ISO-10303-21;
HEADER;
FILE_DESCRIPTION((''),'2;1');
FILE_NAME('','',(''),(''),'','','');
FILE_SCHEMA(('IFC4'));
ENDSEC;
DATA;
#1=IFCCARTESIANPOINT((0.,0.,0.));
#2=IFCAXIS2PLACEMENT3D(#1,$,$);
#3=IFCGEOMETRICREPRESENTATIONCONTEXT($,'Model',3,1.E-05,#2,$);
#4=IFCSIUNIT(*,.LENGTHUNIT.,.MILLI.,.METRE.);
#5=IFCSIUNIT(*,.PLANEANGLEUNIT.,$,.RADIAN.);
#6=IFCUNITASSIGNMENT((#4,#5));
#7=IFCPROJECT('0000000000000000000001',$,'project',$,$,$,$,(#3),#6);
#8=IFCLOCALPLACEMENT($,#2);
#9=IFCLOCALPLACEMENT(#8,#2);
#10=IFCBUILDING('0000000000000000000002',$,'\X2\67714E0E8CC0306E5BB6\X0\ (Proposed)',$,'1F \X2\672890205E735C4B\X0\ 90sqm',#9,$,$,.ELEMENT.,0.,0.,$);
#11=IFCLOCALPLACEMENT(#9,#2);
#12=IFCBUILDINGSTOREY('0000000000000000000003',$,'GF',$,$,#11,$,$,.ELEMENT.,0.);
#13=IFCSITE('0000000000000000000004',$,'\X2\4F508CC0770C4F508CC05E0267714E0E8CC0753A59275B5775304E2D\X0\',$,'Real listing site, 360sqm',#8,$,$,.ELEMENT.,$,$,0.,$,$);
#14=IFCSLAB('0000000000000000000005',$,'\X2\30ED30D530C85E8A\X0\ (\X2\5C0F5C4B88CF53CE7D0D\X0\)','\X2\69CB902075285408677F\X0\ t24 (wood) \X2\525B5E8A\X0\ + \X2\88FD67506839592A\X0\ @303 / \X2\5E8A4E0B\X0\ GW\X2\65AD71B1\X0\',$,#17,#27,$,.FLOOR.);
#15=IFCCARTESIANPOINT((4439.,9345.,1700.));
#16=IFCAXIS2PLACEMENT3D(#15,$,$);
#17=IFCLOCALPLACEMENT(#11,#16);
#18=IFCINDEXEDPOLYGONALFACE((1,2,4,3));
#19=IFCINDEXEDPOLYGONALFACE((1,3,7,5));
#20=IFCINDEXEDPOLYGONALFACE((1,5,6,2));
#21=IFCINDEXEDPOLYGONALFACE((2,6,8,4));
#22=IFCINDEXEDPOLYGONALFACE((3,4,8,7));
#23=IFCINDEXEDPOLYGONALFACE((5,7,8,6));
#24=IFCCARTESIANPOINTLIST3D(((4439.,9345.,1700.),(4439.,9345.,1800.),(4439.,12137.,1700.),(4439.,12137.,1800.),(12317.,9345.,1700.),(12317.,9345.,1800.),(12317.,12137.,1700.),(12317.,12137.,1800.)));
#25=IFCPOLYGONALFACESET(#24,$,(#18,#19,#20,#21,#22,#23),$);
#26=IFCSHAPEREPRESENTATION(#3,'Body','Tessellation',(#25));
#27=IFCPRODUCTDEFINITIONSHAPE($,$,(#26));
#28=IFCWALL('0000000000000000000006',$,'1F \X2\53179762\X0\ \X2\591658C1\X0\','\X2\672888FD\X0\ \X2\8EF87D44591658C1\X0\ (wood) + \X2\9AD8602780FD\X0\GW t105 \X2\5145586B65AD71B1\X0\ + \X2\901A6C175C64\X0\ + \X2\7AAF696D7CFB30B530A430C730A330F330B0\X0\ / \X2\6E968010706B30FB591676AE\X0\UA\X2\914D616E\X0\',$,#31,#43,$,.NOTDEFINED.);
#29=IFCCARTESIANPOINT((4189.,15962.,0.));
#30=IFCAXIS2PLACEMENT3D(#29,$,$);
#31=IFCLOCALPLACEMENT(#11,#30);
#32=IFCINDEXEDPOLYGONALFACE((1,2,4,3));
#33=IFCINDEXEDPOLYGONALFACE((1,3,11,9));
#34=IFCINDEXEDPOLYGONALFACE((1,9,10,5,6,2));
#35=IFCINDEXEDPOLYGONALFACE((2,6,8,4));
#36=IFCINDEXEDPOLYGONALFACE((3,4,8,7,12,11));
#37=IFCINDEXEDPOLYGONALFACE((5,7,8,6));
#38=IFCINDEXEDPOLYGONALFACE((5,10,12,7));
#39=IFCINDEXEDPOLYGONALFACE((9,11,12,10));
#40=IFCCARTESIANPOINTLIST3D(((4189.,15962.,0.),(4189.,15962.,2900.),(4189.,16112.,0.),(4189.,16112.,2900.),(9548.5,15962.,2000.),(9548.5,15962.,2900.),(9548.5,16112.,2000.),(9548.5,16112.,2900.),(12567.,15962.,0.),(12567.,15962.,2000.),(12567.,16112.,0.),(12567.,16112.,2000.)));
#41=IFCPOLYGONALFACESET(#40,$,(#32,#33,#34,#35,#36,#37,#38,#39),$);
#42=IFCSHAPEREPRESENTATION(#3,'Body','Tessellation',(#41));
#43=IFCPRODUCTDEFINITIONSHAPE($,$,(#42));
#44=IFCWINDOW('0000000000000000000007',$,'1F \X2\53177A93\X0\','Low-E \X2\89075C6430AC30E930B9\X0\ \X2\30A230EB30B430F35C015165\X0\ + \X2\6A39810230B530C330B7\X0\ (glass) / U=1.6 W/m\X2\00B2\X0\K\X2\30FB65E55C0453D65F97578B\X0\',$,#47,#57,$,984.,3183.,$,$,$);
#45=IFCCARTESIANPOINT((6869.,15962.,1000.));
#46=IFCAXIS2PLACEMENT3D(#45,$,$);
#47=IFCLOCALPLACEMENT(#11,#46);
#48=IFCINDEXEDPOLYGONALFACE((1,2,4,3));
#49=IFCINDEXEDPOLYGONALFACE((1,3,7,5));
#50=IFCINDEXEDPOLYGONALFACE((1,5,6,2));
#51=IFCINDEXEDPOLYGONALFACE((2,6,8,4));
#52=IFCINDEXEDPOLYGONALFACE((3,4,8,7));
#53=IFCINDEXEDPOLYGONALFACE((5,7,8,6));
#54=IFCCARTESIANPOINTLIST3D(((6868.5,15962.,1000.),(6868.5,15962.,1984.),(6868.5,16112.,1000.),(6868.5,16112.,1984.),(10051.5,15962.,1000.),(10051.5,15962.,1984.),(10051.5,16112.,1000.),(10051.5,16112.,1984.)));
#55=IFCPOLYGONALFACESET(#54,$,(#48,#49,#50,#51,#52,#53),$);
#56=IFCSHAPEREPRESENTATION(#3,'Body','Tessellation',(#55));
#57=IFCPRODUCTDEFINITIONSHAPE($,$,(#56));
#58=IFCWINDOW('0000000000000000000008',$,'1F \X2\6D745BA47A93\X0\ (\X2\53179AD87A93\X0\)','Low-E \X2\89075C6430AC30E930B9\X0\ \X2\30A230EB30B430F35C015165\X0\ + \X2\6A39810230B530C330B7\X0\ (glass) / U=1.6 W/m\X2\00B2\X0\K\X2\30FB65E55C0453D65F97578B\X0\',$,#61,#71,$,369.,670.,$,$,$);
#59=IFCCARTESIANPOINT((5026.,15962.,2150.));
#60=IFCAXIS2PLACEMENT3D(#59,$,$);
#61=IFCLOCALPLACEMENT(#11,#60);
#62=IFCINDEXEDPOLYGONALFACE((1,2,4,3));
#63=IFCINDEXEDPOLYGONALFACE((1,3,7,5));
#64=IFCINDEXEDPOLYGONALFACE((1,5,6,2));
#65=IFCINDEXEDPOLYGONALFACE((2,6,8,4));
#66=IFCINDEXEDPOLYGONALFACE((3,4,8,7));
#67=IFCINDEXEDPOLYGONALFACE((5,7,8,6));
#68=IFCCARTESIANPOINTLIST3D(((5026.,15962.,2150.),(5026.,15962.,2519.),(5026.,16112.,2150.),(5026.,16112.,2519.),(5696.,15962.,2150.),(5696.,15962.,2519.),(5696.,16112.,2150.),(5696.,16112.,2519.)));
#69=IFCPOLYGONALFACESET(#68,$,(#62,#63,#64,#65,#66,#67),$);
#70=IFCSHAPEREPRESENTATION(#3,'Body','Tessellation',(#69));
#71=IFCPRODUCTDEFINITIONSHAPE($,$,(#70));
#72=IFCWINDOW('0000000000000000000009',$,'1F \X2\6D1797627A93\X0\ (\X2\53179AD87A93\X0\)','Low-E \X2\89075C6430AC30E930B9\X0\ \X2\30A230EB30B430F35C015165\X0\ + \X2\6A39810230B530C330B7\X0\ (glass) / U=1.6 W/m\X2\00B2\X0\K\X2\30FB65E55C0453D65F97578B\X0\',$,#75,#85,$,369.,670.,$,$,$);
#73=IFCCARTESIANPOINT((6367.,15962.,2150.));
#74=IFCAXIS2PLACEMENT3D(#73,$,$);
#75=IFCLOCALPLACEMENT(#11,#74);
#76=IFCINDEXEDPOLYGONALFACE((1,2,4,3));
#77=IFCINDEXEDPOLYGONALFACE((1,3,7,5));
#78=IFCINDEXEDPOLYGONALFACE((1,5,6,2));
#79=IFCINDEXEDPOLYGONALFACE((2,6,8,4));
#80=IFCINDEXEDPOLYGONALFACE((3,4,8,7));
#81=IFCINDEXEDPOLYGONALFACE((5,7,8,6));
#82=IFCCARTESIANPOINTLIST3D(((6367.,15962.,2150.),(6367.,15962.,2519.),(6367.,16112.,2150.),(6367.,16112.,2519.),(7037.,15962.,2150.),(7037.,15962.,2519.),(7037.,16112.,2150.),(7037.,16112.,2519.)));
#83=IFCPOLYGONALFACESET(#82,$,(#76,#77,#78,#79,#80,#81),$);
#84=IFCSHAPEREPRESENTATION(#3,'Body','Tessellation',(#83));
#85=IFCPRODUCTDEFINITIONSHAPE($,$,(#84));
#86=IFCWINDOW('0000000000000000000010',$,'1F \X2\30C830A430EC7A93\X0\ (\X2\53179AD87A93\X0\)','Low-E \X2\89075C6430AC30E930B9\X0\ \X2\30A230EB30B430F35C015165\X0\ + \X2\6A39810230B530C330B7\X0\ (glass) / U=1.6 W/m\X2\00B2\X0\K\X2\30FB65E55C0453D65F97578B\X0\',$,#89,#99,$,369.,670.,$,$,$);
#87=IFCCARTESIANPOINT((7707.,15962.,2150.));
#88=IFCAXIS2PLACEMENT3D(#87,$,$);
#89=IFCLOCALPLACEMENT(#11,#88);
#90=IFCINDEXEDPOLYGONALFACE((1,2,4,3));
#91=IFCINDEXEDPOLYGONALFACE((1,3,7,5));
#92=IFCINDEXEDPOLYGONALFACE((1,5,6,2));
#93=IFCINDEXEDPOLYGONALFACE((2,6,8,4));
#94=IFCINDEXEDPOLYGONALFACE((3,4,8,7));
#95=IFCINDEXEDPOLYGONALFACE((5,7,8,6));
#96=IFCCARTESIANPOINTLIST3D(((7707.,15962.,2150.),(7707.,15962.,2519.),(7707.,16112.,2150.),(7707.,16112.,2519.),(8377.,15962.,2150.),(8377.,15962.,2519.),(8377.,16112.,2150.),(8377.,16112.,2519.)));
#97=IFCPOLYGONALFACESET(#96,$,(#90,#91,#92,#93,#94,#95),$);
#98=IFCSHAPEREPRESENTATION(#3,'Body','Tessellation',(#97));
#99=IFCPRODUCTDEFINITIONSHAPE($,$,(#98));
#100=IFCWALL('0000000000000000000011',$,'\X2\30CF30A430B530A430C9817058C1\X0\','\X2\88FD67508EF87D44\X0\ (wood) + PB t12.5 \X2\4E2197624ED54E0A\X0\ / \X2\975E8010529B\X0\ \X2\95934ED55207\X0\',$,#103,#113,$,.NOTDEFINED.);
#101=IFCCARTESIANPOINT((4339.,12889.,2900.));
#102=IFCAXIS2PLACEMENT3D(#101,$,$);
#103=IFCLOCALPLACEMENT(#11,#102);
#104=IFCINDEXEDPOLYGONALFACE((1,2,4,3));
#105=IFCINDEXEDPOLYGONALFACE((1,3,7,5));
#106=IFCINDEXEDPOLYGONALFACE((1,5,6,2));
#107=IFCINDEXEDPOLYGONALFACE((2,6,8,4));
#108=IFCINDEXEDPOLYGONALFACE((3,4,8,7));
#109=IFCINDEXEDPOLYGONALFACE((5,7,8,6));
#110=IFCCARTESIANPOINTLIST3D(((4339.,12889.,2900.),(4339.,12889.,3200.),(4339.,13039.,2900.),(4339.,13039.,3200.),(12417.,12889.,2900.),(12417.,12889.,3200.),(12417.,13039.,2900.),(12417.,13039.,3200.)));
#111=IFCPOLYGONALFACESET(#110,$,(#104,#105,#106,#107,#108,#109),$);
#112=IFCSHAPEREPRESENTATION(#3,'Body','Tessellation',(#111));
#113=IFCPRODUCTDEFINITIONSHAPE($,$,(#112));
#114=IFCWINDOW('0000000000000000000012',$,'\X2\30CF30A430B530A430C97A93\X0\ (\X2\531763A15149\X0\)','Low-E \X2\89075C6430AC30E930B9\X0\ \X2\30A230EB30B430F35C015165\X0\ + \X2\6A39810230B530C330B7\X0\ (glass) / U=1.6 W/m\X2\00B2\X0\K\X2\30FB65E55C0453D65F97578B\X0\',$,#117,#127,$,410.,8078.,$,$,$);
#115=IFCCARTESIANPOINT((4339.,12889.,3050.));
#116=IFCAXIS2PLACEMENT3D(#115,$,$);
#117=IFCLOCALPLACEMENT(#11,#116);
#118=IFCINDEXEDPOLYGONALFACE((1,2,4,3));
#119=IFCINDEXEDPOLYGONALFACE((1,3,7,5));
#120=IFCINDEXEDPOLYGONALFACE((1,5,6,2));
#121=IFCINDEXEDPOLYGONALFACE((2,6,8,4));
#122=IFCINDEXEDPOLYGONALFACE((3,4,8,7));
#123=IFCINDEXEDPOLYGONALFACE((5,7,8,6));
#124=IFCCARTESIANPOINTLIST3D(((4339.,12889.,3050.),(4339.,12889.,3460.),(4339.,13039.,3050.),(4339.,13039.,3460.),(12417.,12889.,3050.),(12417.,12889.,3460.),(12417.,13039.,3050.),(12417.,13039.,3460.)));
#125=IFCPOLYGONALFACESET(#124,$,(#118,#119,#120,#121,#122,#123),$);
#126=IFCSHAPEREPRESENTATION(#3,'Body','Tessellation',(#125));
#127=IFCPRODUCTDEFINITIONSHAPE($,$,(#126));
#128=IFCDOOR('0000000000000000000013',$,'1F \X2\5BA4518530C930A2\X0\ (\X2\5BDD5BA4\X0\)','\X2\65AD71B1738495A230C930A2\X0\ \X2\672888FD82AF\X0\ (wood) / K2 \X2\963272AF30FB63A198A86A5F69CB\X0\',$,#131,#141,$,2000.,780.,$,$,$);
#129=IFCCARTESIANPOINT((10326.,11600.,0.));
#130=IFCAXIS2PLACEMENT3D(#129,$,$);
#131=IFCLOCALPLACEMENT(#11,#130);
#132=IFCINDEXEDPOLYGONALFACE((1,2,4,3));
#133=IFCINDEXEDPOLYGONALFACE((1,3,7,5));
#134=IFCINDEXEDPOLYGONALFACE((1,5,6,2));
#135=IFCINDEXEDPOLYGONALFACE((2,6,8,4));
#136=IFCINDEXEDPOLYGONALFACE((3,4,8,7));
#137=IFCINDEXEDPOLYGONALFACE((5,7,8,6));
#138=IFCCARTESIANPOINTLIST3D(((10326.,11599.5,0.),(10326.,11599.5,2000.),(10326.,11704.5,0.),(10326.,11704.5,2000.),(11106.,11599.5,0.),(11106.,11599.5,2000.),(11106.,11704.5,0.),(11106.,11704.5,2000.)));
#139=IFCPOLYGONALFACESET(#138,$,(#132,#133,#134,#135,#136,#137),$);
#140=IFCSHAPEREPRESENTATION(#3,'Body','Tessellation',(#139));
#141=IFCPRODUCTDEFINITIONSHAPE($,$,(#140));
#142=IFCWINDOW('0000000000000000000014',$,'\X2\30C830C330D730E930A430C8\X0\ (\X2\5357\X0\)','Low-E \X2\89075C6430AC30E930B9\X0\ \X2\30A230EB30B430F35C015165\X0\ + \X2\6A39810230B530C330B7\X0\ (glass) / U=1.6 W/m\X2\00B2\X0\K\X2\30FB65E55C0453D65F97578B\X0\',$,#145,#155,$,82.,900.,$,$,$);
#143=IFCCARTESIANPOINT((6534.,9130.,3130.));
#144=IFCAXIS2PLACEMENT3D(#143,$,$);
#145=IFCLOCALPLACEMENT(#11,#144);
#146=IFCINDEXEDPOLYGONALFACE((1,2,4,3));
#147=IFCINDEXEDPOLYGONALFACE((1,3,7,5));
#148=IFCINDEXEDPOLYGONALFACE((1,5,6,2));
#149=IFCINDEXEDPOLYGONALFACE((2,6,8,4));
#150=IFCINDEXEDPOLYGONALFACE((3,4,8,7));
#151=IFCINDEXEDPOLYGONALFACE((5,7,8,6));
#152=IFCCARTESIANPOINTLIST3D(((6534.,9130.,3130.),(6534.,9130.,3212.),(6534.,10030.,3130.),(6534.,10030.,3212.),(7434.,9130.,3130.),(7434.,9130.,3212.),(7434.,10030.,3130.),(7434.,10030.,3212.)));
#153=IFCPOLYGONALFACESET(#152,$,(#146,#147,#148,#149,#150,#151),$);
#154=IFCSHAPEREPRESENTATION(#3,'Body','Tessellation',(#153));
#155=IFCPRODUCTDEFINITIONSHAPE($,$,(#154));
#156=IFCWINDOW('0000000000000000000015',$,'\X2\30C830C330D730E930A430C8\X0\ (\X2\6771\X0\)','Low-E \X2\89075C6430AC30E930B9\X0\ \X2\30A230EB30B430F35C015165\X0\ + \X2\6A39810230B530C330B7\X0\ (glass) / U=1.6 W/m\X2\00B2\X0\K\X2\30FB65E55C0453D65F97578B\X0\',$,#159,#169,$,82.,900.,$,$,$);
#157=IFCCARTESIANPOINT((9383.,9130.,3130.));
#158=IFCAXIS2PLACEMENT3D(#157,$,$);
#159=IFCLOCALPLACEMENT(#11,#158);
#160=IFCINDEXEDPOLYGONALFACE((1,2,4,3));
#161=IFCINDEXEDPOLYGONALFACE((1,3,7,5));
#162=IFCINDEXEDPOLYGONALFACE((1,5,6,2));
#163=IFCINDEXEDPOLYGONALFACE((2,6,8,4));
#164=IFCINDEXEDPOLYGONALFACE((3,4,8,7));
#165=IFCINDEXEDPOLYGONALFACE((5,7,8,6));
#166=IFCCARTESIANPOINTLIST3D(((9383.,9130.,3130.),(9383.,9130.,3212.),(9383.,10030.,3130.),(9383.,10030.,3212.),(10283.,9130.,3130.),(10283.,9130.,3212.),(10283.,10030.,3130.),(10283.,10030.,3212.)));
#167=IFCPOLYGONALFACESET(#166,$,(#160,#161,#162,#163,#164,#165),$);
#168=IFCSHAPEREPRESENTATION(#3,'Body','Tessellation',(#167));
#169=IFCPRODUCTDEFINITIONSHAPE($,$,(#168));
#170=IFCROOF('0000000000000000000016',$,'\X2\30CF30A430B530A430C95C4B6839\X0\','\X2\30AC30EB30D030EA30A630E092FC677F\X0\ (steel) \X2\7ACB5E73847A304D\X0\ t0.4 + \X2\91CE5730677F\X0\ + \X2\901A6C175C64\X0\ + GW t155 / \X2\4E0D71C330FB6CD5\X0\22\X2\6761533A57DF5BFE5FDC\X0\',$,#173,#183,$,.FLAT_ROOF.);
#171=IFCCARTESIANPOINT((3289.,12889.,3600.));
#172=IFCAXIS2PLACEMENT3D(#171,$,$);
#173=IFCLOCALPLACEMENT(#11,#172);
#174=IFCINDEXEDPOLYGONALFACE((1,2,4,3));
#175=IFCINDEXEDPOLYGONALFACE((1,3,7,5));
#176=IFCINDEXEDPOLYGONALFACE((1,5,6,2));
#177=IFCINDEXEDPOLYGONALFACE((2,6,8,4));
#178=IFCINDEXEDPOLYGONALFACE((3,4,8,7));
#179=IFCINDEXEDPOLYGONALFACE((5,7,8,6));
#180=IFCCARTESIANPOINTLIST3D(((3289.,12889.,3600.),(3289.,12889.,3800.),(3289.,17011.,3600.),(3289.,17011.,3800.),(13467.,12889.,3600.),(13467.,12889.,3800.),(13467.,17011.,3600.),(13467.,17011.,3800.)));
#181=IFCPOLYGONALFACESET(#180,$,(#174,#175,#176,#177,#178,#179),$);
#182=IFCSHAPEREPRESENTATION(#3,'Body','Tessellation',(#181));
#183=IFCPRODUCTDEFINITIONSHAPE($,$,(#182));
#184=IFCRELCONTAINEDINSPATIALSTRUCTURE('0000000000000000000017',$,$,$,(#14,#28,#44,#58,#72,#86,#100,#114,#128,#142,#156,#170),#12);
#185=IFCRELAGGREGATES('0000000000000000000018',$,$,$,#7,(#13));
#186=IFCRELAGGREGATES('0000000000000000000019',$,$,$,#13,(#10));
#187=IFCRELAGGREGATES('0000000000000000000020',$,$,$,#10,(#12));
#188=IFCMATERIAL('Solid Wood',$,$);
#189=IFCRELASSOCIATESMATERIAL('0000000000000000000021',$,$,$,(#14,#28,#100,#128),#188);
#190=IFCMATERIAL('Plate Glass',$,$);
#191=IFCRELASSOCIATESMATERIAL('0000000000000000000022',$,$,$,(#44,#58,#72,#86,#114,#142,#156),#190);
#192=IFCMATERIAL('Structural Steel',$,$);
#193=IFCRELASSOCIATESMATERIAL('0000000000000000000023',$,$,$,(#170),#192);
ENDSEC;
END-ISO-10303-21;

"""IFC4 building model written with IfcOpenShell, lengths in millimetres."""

from ifc_helpers import new_model, si_unit, frame, frame_2d, origin, place, context, project, spatial, rectangle, extrude, material, element, fill, save


model = new_model("IFC4")

# Units and contexts
model_context = context("Model", 3, precision=1e-05, world=origin())
ifc_project = project(units=[si_unit("LENGTHUNIT", "METRE", prefix="MILLI"), si_unit("PLANEANGLEUNIT", "RADIAN")], contexts=[model_context])

# Site, building, storey
site_placement = place(None, origin())
site = spatial("IfcSite", under=ifc_project, at=site_placement, Name="佐賀県佐賀市東与賀町大字田中", ObjectType="Real listing site, 360sqm", CompositionType="ELEMENT", RefElevation=0.0)
building_placement = place(site_placement, origin())
building = spatial("IfcBuilding", under=site, at=building_placement, Name="東与賀の家 (Proposed)", ObjectType="1F 木造平屋 90sqm", CompositionType="ELEMENT", ElevationOfRefHeight=0.0, ElevationOfTerrain=0.0)
storey_placement = place(building_placement, origin())
storey = spatial("IfcBuildingStorey", under=building, at=storey_placement, Name="GF", CompositionType="ELEMENT", Elevation=0.0)

# Slab
ifc_material_1 = material(Name="Solid Wood")
slab_placement = place(storey_placement, frame((4439.0, 9345.0, 1700.0)))
element("IfcSlab", 1, at=slab_placement, inside=storey, material=ifc_material_1, Name="ロフト床 (小屋裏収納)", Description="構造用合板 t24 (wood) 剛床 + 製材根太 @303 / 床下 GW断熱", PredefinedType="FLOOR", context=model_context, shape_type="SweptSolid", body=[
    extrude(rectangle(XDim=7878.0, YDim=2792.0, at=frame_2d((3939.0, 1396.0))), frame((4439.0, 9345.0, 1700.0)), (0.0, 0.0, 1.0), 100.0),
])

# Wall, openings, windows
wall_1_placement = place(storey_placement, frame((4189.0, 15962.0, 0.0)))
wall_1 = element("IfcWall", 2, at=wall_1_placement, inside=storey, material=ifc_material_1, Name="1F 北面 外壁", Description="木製 軸組外壁 (wood) + 高性能GW t105 充填断熱 + 通気層 + 窯業系サイディング / 準耐火・外皮UA配慮", PredefinedType="NOTDEFINED", context=model_context, shape_type="SweptSolid", body=[
    extrude(rectangle(XDim=8378.0, YDim=150.0, at=frame_2d((4189.0, 75.0))), frame((4189.0, 15962.0, 0.0)), (0.0, 0.0, 1.0), 2900.0),
])
opening_1_placement = place(storey_placement, frame((6869.0, 15962.0, 1000.0)))
opening_1 = element("IfcOpeningElement", 3, at=opening_1_placement, cuts=wall_1, PredefinedType="NOTDEFINED", context=model_context, shape_type="SweptSolid", body=[
    extrude(rectangle(XDim=3183.0, YDim=150.0, at=frame_2d((1591.0, 75.0))), frame((6869.0, 15962.0, 1000.0)), (0.0, 0.0, 1.0), 984.0),
])
opening_2_placement = place(storey_placement, frame((5026.0, 15962.0, 2150.0)))
opening_2 = element("IfcOpeningElement", 4, at=opening_2_placement, cuts=wall_1, PredefinedType="NOTDEFINED", context=model_context, shape_type="SweptSolid", body=[
    extrude(rectangle(XDim=670.0, YDim=150.0, at=frame_2d((335.0, 75.0))), frame((5026.0, 15962.0, 2150.0)), (0.0, 0.0, 1.0), 369.0),
])
opening_3_placement = place(storey_placement, frame((6367.0, 15962.0, 2150.0)))
opening_3 = element("IfcOpeningElement", 5, at=opening_3_placement, cuts=wall_1, PredefinedType="NOTDEFINED", context=model_context, shape_type="SweptSolid", body=[
    extrude(rectangle(XDim=670.0, YDim=150.0, at=frame_2d((335.0, 75.0))), frame((6367.0, 15962.0, 2150.0)), (0.0, 0.0, 1.0), 369.0),
])
opening_4_placement = place(storey_placement, frame((7707.0, 15962.0, 2150.0)))
opening_4 = element("IfcOpeningElement", 6, at=opening_4_placement, cuts=wall_1, PredefinedType="NOTDEFINED", context=model_context, shape_type="SweptSolid", body=[
    extrude(rectangle(XDim=670.0, YDim=150.0, at=frame_2d((335.0, 75.0))), frame((7707.0, 15962.0, 2150.0)), (0.0, 0.0, 1.0), 369.0),
])
ifc_material_2 = material(Name="Plate Glass")
window_1_placement = place(storey_placement, frame((6869.0, 15962.0, 1000.0)))
window_1 = element("IfcWindow", 7, at=window_1_placement, inside=storey, material=ifc_material_2, Name="1F 北窓", Description="Low-E 複層ガラス アルゴン封入 + 樹脂サッシ (glass) / U=1.6 W/m²K・日射取得型", OverallHeight=984.0, OverallWidth=3183.0, context=model_context, shape_type="SweptSolid", body=[
    extrude(rectangle(XDim=3183.0, YDim=150.0, at=frame_2d((1591.0, 75.0))), frame((6869.0, 15962.0, 1000.0)), (0.0, 0.0, 1.0), 984.0),
])
fill(opening_1, window_1)
window_2_placement = place(storey_placement, frame((5026.0, 15962.0, 2150.0)))
window_2 = element("IfcWindow", 8, at=window_2_placement, inside=storey, material=ifc_material_2, Name="1F 浴室窓 (北高窓)", Description="Low-E 複層ガラス アルゴン封入 + 樹脂サッシ (glass) / U=1.6 W/m²K・日射取得型", OverallHeight=369.0, OverallWidth=670.0, context=model_context, shape_type="SweptSolid", body=[
    extrude(rectangle(XDim=670.0, YDim=150.0, at=frame_2d((335.0, 75.0))), frame((5026.0, 15962.0, 2150.0)), (0.0, 0.0, 1.0), 369.0),
])
fill(opening_2, window_2)
window_3_placement = place(storey_placement, frame((6367.0, 15962.0, 2150.0)))
window_3 = element("IfcWindow", 9, at=window_3_placement, inside=storey, material=ifc_material_2, Name="1F 洗面窓 (北高窓)", Description="Low-E 複層ガラス アルゴン封入 + 樹脂サッシ (glass) / U=1.6 W/m²K・日射取得型", OverallHeight=369.0, OverallWidth=670.0, context=model_context, shape_type="SweptSolid", body=[
    extrude(rectangle(XDim=670.0, YDim=150.0, at=frame_2d((335.0, 75.0))), frame((6367.0, 15962.0, 2150.0)), (0.0, 0.0, 1.0), 369.0),
])
fill(opening_3, window_3)
window_4_placement = place(storey_placement, frame((7707.0, 15962.0, 2150.0)))
window_4 = element("IfcWindow", 10, at=window_4_placement, inside=storey, material=ifc_material_2, Name="1F トイレ窓 (北高窓)", Description="Low-E 複層ガラス アルゴン封入 + 樹脂サッシ (glass) / U=1.6 W/m²K・日射取得型", OverallHeight=369.0, OverallWidth=670.0, context=model_context, shape_type="SweptSolid", body=[
    extrude(rectangle(XDim=670.0, YDim=150.0, at=frame_2d((335.0, 75.0))), frame((7707.0, 15962.0, 2150.0)), (0.0, 0.0, 1.0), 369.0),
])
fill(opening_4, window_4)

# Wall, opening, window
wall_2_placement = place(storey_placement, frame((4339.0, 12889.0, 2900.0)))
wall_2 = element("IfcWall", 11, at=wall_2_placement, inside=storey, material=ifc_material_1, Name="ハイサイド腰壁", Description="製材軸組 (wood) + PB t12.5 両面仕上 / 非耐力 間仕切", PredefinedType="NOTDEFINED", context=model_context, shape_type="SweptSolid", body=[
    extrude(rectangle(XDim=8078.0, YDim=150.0, at=frame_2d((4039.0, 75.0))), frame((4339.0, 12889.0, 2900.0)), (0.0, 0.0, 1.0), 700.0),
])
opening_5_placement = place(storey_placement, frame((4339.0, 12889.0, 3050.0)))
opening_5 = element("IfcOpeningElement", 12, at=opening_5_placement, cuts=wall_2, PredefinedType="NOTDEFINED", context=model_context, shape_type="SweptSolid", body=[
    extrude(rectangle(XDim=8078.0, YDim=150.0, at=frame_2d((4039.0, 75.0))), frame((4339.0, 12889.0, 3050.0)), (0.0, 0.0, 1.0), 410.0),
])
window_5_placement = place(storey_placement, frame((4339.0, 12889.0, 3050.0)))
window_5 = element("IfcWindow", 13, at=window_5_placement, inside=storey, material=ifc_material_2, Name="ハイサイド窓 (北採光)", Description="Low-E 複層ガラス アルゴン封入 + 樹脂サッシ (glass) / U=1.6 W/m²K・日射取得型", OverallHeight=410.0, OverallWidth=8078.0, context=model_context, shape_type="SweptSolid", body=[
    extrude(rectangle(XDim=8078.0, YDim=150.0, at=frame_2d((4039.0, 75.0))), frame((4339.0, 12889.0, 3050.0)), (0.0, 0.0, 1.0), 410.0),
])
fill(opening_5, window_5)

# Door
door_1_placement = place(storey_placement, frame((10326.0, 11600.0, 0.0)))
element("IfcDoor", 14, at=door_1_placement, inside=storey, material=ifc_material_1, Name="1F 室内ドア (寝室)", Description="断熱玄関ドア 木製芯 (wood) / K2 防犯・採風機構", OverallHeight=2000.0, OverallWidth=780.0, context=model_context, shape_type="SweptSolid", body=[
    extrude(rectangle(XDim=780.0, YDim=105.0, at=frame_2d((390.0, 52.0))), frame((10326.0, 11600.0, 0.0)), (0.0, 0.0, 1.0), 2000.0),
])

# Windows
window_6_placement = place(storey_placement, frame((6534.0, 9130.0, 3130.0)))
element("IfcWindow", 15, at=window_6_placement, inside=storey, material=ifc_material_2, Name="トップライト (南)", Description="Low-E 複層ガラス アルゴン封入 + 樹脂サッシ (glass) / U=1.6 W/m²K・日射取得型", OverallHeight=82.0, OverallWidth=900.0, context=model_context, shape_type="SweptSolid", body=[
    extrude(rectangle(XDim=900.0, YDim=900.0, at=frame_2d((450.0, 450.0))), frame((6534.0, 9130.0, 3130.0)), (0.0, 0.0, 1.0), 82.0),
])
window_7_placement = place(storey_placement, frame((9383.0, 9130.0, 3130.0)))
element("IfcWindow", 16, at=window_7_placement, inside=storey, material=ifc_material_2, Name="トップライト (東)", Description="Low-E 複層ガラス アルゴン封入 + 樹脂サッシ (glass) / U=1.6 W/m²K・日射取得型", OverallHeight=82.0, OverallWidth=900.0, context=model_context, shape_type="SweptSolid", body=[
    extrude(rectangle(XDim=900.0, YDim=900.0, at=frame_2d((450.0, 450.0))), frame((9383.0, 9130.0, 3130.0)), (0.0, 0.0, 1.0), 82.0),
])

# Roof
ifc_material_3 = material(Name="Structural Steel")
roof_placement = place(storey_placement, frame((3289.0, 12889.0, 3600.0)))
element("IfcRoof", 17, at=roof_placement, inside=storey, material=ifc_material_3, Name="ハイサイド屋根", Description="ガルバリウム鋼板 (steel) 立平葺き t0.4 + 野地板 + 通気層 + GW t155 / 不燃・法22条区域対応", PredefinedType="FLAT_ROOF", context=model_context, shape_type="SweptSolid", body=[
    extrude(rectangle(XDim=10178.0, YDim=4122.0, at=frame_2d((5089.0, 2061.0))), frame((3289.0, 12889.0, 3600.0)), (0.0, 0.0, 1.0), 200.0),
])

save(model, "model.ifc")
